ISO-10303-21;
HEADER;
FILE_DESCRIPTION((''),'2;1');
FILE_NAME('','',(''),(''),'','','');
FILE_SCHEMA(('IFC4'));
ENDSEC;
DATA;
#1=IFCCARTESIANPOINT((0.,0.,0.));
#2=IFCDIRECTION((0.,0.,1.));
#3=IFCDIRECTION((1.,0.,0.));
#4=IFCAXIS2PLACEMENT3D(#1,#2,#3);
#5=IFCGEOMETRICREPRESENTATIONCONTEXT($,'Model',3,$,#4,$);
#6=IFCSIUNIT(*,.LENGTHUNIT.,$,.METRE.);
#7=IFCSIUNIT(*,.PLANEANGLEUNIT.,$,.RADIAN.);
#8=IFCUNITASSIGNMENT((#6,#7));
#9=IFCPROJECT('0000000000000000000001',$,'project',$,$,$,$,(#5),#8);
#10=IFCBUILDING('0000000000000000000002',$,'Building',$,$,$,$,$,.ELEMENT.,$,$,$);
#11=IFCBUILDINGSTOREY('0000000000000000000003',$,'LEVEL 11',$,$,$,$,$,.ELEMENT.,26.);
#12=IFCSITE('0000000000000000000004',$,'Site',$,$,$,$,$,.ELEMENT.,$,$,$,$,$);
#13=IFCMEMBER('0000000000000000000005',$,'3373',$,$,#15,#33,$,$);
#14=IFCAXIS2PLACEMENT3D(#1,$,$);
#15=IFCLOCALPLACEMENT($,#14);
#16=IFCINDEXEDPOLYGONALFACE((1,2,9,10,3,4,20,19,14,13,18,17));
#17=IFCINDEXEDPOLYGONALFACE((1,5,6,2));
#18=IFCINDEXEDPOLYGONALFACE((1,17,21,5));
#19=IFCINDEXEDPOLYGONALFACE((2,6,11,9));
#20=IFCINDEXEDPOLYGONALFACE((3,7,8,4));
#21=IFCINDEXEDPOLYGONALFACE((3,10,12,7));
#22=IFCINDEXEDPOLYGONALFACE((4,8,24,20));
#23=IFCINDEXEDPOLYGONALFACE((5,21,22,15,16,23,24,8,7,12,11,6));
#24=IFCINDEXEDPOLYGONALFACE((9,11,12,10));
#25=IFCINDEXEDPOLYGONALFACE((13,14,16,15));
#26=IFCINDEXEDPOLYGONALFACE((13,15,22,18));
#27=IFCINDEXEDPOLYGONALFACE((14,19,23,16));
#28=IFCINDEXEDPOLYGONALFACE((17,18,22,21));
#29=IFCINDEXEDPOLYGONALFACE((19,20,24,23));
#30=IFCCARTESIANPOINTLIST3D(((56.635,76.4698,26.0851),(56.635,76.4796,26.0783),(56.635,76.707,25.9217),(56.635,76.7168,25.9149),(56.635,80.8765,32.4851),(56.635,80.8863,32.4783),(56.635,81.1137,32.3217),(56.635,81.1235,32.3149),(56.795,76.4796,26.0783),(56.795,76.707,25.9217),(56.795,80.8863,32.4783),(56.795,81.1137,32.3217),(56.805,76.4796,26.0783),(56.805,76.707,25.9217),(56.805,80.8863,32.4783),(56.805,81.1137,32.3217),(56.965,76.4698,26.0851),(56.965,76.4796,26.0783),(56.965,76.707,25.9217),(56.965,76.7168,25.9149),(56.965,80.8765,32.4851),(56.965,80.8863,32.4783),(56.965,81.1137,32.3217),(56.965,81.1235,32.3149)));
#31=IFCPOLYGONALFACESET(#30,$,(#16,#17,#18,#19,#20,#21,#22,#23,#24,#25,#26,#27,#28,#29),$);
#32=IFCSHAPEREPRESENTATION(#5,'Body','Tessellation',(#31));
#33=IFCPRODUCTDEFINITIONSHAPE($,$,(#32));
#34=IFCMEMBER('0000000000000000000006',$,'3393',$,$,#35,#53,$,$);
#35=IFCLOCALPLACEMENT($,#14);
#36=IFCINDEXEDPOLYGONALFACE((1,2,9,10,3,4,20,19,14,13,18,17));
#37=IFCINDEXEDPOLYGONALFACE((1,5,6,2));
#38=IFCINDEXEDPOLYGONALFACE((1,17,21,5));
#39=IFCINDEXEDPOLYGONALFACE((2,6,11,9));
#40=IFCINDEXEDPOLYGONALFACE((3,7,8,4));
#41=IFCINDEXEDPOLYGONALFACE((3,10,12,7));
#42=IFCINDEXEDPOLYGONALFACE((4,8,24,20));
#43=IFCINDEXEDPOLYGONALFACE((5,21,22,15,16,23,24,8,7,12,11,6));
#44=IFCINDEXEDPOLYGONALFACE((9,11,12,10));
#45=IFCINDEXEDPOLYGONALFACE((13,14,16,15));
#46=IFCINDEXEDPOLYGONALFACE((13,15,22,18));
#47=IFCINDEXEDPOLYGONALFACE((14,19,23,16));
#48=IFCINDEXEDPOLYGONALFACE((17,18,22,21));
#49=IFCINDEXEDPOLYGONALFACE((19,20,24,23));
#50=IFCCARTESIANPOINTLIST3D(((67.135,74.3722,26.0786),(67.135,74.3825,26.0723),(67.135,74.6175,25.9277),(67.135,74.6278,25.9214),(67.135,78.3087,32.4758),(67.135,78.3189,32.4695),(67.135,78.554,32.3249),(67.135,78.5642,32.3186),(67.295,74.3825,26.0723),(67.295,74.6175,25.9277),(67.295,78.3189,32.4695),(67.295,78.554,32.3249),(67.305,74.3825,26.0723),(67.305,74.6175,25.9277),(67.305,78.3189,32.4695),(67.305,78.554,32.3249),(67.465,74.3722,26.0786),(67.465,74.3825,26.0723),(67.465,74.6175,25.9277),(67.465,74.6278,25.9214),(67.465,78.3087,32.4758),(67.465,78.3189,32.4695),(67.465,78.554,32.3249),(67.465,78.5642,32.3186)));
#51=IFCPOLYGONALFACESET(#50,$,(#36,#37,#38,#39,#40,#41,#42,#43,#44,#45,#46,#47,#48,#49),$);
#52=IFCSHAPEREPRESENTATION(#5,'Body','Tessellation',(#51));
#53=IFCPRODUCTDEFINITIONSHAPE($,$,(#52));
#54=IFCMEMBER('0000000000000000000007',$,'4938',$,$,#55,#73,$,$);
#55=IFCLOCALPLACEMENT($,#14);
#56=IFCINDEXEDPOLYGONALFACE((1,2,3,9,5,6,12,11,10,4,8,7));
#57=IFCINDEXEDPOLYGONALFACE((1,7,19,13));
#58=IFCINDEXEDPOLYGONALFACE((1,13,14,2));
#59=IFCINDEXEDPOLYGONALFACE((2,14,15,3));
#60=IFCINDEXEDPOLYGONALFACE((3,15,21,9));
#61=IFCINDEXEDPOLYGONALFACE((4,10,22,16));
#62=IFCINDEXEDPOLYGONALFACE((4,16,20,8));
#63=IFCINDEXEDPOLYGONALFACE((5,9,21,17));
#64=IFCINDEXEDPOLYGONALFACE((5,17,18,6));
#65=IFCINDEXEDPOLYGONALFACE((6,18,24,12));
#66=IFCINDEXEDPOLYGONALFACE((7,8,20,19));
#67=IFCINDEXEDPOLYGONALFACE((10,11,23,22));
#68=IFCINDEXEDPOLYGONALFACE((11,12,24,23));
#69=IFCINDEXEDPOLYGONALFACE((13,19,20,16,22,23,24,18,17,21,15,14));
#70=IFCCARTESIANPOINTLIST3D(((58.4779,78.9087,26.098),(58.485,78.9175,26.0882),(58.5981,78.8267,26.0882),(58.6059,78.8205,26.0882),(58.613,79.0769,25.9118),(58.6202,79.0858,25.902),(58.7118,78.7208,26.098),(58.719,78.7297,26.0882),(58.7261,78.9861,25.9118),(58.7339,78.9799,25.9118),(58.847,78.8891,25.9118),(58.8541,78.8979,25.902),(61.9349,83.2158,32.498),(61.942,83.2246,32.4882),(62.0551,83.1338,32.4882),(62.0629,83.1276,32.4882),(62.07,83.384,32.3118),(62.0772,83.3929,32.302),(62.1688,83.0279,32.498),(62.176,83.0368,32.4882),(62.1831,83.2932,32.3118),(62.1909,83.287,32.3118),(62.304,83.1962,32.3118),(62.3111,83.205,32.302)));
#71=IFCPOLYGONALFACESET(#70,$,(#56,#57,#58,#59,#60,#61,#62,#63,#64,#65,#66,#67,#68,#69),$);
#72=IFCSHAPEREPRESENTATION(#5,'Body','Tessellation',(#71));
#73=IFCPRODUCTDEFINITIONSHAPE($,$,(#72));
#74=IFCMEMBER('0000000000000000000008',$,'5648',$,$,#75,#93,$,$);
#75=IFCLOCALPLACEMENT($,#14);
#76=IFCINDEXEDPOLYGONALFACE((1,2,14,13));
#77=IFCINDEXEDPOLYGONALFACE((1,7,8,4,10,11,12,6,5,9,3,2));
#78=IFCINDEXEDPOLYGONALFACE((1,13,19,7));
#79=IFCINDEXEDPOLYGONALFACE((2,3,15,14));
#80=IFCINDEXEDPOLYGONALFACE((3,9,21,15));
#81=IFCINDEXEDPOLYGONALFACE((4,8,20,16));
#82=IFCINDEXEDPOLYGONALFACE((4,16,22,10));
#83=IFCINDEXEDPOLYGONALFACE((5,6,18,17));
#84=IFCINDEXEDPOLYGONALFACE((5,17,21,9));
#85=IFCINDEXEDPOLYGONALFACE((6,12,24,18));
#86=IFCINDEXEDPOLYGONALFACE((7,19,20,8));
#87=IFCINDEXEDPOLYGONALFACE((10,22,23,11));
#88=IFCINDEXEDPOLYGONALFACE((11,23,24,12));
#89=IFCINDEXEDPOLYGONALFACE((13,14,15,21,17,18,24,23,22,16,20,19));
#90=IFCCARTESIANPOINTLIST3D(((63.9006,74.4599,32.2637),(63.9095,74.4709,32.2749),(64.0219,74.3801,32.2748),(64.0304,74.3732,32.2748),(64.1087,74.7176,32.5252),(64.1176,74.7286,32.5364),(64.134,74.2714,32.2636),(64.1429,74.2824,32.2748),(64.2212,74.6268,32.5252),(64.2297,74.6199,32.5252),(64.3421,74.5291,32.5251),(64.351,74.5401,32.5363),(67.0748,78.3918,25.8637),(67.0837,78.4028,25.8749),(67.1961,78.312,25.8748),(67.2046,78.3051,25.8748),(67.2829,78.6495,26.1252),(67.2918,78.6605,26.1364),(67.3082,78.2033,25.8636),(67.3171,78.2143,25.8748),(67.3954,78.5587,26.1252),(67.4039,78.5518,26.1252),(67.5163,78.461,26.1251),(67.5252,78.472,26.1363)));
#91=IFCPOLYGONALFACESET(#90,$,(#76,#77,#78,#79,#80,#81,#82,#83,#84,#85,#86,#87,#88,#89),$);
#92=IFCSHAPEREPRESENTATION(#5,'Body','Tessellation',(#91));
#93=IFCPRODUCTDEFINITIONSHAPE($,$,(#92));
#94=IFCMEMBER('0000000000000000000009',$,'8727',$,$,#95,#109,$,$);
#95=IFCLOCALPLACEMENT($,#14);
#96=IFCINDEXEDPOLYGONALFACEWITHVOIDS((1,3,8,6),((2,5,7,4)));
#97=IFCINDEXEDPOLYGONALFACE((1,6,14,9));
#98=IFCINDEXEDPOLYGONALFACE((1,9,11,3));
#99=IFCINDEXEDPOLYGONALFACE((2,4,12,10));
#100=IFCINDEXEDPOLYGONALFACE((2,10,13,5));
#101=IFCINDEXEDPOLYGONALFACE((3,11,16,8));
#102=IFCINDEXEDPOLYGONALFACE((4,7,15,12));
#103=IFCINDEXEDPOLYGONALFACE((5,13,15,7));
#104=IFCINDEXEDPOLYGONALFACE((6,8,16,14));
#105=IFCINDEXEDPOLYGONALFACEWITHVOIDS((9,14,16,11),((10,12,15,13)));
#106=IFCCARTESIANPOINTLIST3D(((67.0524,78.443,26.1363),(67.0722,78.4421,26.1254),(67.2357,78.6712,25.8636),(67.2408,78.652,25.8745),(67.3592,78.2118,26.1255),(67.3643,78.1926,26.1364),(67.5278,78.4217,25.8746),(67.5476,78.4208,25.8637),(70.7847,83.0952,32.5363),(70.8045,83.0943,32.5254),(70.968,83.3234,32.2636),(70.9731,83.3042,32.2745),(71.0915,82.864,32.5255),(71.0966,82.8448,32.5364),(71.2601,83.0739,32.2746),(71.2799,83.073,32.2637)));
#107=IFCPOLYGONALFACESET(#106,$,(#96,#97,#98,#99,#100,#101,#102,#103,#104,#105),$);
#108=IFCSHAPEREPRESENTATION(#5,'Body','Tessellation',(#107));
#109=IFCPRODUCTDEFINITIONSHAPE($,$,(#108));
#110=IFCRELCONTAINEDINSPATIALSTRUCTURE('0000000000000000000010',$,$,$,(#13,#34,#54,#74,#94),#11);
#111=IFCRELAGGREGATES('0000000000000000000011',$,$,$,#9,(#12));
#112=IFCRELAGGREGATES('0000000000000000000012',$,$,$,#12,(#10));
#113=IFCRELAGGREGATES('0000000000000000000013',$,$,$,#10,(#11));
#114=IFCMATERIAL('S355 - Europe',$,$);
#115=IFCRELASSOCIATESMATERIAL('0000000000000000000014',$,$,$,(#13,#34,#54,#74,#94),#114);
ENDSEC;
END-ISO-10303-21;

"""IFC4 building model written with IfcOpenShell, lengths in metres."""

from ifc_helpers import new_model, si_unit, frame, origin_with_axes, origin_2d_with_axis, place, context, project, spatial, hollow_rectangle, i_section, extrude, material, material_profile, profile_set, profile_usage, element, save


model = new_model("IFC4")

# Units and contexts
model_context = context("Model", 3, world=origin_with_axes())
ifc_project = project(units=[si_unit("LENGTHUNIT", "METRE"), si_unit("PLANEANGLEUNIT", "RADIAN")], contexts=[model_context])

# Site, building, storey
site = spatial("IfcSite", under=ifc_project, Name="Site", CompositionType="ELEMENT")
building = spatial("IfcBuilding", under=site, Name="Building", CompositionType="ELEMENT")
storey = spatial("IfcBuildingStorey", under=building, Name="LEVEL 11", CompositionType="ELEMENT", Elevation=26.0)

# Shared definitions
ifc_material = material(Name="S355 - Europe")

# Members
ifc_material_profile_1 = material_profile(ifc_material, i_section(OverallWidth=0.33, OverallDepth=0.3, WebThickness=0.01, FlangeThickness=0.012, at=origin_2d_with_axis()))
ifc_profile_set_1 = profile_set([ifc_material_profile_1])
ifc_profile_usage_1 = profile_usage(ifc_profile_set_1, cardinal=10)
member_1_placement = place(None, frame((56.8, 81.0, 32.4), z_axis=(0.0, -0.567114, -0.823639), x_axis=(1.0, 0.0, 0.0)))
element("IfcMember", 1, at=member_1_placement, inside=storey, material=ifc_profile_usage_1, Name="3373", context=model_context, shape_type="SweptSolid", body=[
    extrude(i_section(OverallWidth=0.33, OverallDepth=0.3, WebThickness=0.01, FlangeThickness=0.012, at=origin_2d_with_axis()), origin_with_axes(), (0.0, 0.0, 1.0), 7.7704),
])
ifc_material_profile_2 = material_profile(ifc_material, i_section(OverallWidth=0.33, OverallDepth=0.3, WebThickness=0.01, FlangeThickness=0.012, at=origin_2d_with_axis()))
ifc_profile_set_2 = profile_set([ifc_material_profile_2])
ifc_profile_usage_2 = profile_usage(ifc_profile_set_2, cardinal=10)
member_2_placement = place(None, frame((67.3, 74.5, 26.0), z_axis=(0.0, 0.524072, 0.851674), x_axis=(-1.0, 0.0, 0.0)))
element("IfcMember", 2, at=member_2_placement, inside=storey, material=ifc_profile_usage_2, Name="3393", context=model_context, shape_type="SweptSolid", body=[
    extrude(i_section(OverallWidth=0.33, OverallDepth=0.3, WebThickness=0.01, FlangeThickness=0.012, at=origin_2d_with_axis()), origin_with_axes(), (0.0, 0.0, 1.0), 7.5113),
])
ifc_material_profile_3 = material_profile(ifc_material, i_section(OverallWidth=0.3, OverallDepth=0.3, WebThickness=0.01, FlangeThickness=0.015, at=origin_2d_with_axis()))
ifc_profile_set_3 = profile_set([ifc_material_profile_3])
ifc_profile_usage_3 = profile_usage(ifc_profile_set_3, cardinal=10)
member_3_placement = place(None, frame((58.666, 78.9033, 26.0), z_axis=(0.408942, 0.509504, 0.757081), x_axis=(-0.779651, 0.626214, 0.0)))
element("IfcMember", 3, at=member_3_placement, inside=storey, material=ifc_profile_usage_3, Name="4938", context=model_context, shape_type="SweptSolid", body=[
    extrude(i_section(OverallWidth=0.3, OverallDepth=0.3, WebThickness=0.01, FlangeThickness=0.015, at=origin_2d_with_axis()), origin_with_axes(), (0.0, 0.0, 1.0), 8.4535),
])
ifc_material_profile_4 = material_profile(ifc_material, i_section(OverallWidth=0.3, OverallDepth=0.44, WebThickness=0.011, FlangeThickness=0.018, at=origin_2d_with_axis()))
ifc_profile_set_4 = profile_set([ifc_material_profile_4])
ifc_profile_usage_4 = profile_usage(ifc_profile_set_4, cardinal=10)
member_4_placement = place(None, frame((64.1258, 74.5, 32.4), z_axis=(0.389259, 0.482177, -0.784846), x_axis=(-0.777826, 0.62848, 0.0)))
element("IfcMember", 4, at=member_4_placement, inside=storey, material=ifc_profile_usage_4, Name="5648", context=model_context, shape_type="SweptSolid", body=[
    extrude(i_section(OverallWidth=0.3, OverallDepth=0.44, WebThickness=0.011, FlangeThickness=0.018, at=origin_2d_with_axis()), origin_with_axes(), (0.0, 0.0, 1.0), 8.1545),
])
ifc_material_profile_5 = material_profile(ifc_material, hollow_rectangle(XDim=0.4, YDim=0.4, WallThickness=0.016, at=origin_2d_with_axis()))
ifc_profile_set_5 = profile_set([ifc_material_profile_5])
ifc_profile_usage_5 = profile_usage(ifc_profile_set_5, cardinal=10)
member_5_placement = place(None, frame((67.3, 78.4319, 26.0), z_axis=(0.426631, 0.531782, 0.731569), x_axis=(-0.779651, 0.626214, 0.0)))
element("IfcMember", 5, at=member_5_placement, inside=storey, material=ifc_profile_usage_5, Name="8727", context=model_context, shape_type="SweptSolid", body=[
    extrude(hollow_rectangle(XDim=0.4, YDim=0.4, WallThickness=0.016, at=origin_2d_with_axis()), origin_with_axes(), (0.0, 0.0, 1.0), 8.7483),
])

save(model, "model.ifc")
